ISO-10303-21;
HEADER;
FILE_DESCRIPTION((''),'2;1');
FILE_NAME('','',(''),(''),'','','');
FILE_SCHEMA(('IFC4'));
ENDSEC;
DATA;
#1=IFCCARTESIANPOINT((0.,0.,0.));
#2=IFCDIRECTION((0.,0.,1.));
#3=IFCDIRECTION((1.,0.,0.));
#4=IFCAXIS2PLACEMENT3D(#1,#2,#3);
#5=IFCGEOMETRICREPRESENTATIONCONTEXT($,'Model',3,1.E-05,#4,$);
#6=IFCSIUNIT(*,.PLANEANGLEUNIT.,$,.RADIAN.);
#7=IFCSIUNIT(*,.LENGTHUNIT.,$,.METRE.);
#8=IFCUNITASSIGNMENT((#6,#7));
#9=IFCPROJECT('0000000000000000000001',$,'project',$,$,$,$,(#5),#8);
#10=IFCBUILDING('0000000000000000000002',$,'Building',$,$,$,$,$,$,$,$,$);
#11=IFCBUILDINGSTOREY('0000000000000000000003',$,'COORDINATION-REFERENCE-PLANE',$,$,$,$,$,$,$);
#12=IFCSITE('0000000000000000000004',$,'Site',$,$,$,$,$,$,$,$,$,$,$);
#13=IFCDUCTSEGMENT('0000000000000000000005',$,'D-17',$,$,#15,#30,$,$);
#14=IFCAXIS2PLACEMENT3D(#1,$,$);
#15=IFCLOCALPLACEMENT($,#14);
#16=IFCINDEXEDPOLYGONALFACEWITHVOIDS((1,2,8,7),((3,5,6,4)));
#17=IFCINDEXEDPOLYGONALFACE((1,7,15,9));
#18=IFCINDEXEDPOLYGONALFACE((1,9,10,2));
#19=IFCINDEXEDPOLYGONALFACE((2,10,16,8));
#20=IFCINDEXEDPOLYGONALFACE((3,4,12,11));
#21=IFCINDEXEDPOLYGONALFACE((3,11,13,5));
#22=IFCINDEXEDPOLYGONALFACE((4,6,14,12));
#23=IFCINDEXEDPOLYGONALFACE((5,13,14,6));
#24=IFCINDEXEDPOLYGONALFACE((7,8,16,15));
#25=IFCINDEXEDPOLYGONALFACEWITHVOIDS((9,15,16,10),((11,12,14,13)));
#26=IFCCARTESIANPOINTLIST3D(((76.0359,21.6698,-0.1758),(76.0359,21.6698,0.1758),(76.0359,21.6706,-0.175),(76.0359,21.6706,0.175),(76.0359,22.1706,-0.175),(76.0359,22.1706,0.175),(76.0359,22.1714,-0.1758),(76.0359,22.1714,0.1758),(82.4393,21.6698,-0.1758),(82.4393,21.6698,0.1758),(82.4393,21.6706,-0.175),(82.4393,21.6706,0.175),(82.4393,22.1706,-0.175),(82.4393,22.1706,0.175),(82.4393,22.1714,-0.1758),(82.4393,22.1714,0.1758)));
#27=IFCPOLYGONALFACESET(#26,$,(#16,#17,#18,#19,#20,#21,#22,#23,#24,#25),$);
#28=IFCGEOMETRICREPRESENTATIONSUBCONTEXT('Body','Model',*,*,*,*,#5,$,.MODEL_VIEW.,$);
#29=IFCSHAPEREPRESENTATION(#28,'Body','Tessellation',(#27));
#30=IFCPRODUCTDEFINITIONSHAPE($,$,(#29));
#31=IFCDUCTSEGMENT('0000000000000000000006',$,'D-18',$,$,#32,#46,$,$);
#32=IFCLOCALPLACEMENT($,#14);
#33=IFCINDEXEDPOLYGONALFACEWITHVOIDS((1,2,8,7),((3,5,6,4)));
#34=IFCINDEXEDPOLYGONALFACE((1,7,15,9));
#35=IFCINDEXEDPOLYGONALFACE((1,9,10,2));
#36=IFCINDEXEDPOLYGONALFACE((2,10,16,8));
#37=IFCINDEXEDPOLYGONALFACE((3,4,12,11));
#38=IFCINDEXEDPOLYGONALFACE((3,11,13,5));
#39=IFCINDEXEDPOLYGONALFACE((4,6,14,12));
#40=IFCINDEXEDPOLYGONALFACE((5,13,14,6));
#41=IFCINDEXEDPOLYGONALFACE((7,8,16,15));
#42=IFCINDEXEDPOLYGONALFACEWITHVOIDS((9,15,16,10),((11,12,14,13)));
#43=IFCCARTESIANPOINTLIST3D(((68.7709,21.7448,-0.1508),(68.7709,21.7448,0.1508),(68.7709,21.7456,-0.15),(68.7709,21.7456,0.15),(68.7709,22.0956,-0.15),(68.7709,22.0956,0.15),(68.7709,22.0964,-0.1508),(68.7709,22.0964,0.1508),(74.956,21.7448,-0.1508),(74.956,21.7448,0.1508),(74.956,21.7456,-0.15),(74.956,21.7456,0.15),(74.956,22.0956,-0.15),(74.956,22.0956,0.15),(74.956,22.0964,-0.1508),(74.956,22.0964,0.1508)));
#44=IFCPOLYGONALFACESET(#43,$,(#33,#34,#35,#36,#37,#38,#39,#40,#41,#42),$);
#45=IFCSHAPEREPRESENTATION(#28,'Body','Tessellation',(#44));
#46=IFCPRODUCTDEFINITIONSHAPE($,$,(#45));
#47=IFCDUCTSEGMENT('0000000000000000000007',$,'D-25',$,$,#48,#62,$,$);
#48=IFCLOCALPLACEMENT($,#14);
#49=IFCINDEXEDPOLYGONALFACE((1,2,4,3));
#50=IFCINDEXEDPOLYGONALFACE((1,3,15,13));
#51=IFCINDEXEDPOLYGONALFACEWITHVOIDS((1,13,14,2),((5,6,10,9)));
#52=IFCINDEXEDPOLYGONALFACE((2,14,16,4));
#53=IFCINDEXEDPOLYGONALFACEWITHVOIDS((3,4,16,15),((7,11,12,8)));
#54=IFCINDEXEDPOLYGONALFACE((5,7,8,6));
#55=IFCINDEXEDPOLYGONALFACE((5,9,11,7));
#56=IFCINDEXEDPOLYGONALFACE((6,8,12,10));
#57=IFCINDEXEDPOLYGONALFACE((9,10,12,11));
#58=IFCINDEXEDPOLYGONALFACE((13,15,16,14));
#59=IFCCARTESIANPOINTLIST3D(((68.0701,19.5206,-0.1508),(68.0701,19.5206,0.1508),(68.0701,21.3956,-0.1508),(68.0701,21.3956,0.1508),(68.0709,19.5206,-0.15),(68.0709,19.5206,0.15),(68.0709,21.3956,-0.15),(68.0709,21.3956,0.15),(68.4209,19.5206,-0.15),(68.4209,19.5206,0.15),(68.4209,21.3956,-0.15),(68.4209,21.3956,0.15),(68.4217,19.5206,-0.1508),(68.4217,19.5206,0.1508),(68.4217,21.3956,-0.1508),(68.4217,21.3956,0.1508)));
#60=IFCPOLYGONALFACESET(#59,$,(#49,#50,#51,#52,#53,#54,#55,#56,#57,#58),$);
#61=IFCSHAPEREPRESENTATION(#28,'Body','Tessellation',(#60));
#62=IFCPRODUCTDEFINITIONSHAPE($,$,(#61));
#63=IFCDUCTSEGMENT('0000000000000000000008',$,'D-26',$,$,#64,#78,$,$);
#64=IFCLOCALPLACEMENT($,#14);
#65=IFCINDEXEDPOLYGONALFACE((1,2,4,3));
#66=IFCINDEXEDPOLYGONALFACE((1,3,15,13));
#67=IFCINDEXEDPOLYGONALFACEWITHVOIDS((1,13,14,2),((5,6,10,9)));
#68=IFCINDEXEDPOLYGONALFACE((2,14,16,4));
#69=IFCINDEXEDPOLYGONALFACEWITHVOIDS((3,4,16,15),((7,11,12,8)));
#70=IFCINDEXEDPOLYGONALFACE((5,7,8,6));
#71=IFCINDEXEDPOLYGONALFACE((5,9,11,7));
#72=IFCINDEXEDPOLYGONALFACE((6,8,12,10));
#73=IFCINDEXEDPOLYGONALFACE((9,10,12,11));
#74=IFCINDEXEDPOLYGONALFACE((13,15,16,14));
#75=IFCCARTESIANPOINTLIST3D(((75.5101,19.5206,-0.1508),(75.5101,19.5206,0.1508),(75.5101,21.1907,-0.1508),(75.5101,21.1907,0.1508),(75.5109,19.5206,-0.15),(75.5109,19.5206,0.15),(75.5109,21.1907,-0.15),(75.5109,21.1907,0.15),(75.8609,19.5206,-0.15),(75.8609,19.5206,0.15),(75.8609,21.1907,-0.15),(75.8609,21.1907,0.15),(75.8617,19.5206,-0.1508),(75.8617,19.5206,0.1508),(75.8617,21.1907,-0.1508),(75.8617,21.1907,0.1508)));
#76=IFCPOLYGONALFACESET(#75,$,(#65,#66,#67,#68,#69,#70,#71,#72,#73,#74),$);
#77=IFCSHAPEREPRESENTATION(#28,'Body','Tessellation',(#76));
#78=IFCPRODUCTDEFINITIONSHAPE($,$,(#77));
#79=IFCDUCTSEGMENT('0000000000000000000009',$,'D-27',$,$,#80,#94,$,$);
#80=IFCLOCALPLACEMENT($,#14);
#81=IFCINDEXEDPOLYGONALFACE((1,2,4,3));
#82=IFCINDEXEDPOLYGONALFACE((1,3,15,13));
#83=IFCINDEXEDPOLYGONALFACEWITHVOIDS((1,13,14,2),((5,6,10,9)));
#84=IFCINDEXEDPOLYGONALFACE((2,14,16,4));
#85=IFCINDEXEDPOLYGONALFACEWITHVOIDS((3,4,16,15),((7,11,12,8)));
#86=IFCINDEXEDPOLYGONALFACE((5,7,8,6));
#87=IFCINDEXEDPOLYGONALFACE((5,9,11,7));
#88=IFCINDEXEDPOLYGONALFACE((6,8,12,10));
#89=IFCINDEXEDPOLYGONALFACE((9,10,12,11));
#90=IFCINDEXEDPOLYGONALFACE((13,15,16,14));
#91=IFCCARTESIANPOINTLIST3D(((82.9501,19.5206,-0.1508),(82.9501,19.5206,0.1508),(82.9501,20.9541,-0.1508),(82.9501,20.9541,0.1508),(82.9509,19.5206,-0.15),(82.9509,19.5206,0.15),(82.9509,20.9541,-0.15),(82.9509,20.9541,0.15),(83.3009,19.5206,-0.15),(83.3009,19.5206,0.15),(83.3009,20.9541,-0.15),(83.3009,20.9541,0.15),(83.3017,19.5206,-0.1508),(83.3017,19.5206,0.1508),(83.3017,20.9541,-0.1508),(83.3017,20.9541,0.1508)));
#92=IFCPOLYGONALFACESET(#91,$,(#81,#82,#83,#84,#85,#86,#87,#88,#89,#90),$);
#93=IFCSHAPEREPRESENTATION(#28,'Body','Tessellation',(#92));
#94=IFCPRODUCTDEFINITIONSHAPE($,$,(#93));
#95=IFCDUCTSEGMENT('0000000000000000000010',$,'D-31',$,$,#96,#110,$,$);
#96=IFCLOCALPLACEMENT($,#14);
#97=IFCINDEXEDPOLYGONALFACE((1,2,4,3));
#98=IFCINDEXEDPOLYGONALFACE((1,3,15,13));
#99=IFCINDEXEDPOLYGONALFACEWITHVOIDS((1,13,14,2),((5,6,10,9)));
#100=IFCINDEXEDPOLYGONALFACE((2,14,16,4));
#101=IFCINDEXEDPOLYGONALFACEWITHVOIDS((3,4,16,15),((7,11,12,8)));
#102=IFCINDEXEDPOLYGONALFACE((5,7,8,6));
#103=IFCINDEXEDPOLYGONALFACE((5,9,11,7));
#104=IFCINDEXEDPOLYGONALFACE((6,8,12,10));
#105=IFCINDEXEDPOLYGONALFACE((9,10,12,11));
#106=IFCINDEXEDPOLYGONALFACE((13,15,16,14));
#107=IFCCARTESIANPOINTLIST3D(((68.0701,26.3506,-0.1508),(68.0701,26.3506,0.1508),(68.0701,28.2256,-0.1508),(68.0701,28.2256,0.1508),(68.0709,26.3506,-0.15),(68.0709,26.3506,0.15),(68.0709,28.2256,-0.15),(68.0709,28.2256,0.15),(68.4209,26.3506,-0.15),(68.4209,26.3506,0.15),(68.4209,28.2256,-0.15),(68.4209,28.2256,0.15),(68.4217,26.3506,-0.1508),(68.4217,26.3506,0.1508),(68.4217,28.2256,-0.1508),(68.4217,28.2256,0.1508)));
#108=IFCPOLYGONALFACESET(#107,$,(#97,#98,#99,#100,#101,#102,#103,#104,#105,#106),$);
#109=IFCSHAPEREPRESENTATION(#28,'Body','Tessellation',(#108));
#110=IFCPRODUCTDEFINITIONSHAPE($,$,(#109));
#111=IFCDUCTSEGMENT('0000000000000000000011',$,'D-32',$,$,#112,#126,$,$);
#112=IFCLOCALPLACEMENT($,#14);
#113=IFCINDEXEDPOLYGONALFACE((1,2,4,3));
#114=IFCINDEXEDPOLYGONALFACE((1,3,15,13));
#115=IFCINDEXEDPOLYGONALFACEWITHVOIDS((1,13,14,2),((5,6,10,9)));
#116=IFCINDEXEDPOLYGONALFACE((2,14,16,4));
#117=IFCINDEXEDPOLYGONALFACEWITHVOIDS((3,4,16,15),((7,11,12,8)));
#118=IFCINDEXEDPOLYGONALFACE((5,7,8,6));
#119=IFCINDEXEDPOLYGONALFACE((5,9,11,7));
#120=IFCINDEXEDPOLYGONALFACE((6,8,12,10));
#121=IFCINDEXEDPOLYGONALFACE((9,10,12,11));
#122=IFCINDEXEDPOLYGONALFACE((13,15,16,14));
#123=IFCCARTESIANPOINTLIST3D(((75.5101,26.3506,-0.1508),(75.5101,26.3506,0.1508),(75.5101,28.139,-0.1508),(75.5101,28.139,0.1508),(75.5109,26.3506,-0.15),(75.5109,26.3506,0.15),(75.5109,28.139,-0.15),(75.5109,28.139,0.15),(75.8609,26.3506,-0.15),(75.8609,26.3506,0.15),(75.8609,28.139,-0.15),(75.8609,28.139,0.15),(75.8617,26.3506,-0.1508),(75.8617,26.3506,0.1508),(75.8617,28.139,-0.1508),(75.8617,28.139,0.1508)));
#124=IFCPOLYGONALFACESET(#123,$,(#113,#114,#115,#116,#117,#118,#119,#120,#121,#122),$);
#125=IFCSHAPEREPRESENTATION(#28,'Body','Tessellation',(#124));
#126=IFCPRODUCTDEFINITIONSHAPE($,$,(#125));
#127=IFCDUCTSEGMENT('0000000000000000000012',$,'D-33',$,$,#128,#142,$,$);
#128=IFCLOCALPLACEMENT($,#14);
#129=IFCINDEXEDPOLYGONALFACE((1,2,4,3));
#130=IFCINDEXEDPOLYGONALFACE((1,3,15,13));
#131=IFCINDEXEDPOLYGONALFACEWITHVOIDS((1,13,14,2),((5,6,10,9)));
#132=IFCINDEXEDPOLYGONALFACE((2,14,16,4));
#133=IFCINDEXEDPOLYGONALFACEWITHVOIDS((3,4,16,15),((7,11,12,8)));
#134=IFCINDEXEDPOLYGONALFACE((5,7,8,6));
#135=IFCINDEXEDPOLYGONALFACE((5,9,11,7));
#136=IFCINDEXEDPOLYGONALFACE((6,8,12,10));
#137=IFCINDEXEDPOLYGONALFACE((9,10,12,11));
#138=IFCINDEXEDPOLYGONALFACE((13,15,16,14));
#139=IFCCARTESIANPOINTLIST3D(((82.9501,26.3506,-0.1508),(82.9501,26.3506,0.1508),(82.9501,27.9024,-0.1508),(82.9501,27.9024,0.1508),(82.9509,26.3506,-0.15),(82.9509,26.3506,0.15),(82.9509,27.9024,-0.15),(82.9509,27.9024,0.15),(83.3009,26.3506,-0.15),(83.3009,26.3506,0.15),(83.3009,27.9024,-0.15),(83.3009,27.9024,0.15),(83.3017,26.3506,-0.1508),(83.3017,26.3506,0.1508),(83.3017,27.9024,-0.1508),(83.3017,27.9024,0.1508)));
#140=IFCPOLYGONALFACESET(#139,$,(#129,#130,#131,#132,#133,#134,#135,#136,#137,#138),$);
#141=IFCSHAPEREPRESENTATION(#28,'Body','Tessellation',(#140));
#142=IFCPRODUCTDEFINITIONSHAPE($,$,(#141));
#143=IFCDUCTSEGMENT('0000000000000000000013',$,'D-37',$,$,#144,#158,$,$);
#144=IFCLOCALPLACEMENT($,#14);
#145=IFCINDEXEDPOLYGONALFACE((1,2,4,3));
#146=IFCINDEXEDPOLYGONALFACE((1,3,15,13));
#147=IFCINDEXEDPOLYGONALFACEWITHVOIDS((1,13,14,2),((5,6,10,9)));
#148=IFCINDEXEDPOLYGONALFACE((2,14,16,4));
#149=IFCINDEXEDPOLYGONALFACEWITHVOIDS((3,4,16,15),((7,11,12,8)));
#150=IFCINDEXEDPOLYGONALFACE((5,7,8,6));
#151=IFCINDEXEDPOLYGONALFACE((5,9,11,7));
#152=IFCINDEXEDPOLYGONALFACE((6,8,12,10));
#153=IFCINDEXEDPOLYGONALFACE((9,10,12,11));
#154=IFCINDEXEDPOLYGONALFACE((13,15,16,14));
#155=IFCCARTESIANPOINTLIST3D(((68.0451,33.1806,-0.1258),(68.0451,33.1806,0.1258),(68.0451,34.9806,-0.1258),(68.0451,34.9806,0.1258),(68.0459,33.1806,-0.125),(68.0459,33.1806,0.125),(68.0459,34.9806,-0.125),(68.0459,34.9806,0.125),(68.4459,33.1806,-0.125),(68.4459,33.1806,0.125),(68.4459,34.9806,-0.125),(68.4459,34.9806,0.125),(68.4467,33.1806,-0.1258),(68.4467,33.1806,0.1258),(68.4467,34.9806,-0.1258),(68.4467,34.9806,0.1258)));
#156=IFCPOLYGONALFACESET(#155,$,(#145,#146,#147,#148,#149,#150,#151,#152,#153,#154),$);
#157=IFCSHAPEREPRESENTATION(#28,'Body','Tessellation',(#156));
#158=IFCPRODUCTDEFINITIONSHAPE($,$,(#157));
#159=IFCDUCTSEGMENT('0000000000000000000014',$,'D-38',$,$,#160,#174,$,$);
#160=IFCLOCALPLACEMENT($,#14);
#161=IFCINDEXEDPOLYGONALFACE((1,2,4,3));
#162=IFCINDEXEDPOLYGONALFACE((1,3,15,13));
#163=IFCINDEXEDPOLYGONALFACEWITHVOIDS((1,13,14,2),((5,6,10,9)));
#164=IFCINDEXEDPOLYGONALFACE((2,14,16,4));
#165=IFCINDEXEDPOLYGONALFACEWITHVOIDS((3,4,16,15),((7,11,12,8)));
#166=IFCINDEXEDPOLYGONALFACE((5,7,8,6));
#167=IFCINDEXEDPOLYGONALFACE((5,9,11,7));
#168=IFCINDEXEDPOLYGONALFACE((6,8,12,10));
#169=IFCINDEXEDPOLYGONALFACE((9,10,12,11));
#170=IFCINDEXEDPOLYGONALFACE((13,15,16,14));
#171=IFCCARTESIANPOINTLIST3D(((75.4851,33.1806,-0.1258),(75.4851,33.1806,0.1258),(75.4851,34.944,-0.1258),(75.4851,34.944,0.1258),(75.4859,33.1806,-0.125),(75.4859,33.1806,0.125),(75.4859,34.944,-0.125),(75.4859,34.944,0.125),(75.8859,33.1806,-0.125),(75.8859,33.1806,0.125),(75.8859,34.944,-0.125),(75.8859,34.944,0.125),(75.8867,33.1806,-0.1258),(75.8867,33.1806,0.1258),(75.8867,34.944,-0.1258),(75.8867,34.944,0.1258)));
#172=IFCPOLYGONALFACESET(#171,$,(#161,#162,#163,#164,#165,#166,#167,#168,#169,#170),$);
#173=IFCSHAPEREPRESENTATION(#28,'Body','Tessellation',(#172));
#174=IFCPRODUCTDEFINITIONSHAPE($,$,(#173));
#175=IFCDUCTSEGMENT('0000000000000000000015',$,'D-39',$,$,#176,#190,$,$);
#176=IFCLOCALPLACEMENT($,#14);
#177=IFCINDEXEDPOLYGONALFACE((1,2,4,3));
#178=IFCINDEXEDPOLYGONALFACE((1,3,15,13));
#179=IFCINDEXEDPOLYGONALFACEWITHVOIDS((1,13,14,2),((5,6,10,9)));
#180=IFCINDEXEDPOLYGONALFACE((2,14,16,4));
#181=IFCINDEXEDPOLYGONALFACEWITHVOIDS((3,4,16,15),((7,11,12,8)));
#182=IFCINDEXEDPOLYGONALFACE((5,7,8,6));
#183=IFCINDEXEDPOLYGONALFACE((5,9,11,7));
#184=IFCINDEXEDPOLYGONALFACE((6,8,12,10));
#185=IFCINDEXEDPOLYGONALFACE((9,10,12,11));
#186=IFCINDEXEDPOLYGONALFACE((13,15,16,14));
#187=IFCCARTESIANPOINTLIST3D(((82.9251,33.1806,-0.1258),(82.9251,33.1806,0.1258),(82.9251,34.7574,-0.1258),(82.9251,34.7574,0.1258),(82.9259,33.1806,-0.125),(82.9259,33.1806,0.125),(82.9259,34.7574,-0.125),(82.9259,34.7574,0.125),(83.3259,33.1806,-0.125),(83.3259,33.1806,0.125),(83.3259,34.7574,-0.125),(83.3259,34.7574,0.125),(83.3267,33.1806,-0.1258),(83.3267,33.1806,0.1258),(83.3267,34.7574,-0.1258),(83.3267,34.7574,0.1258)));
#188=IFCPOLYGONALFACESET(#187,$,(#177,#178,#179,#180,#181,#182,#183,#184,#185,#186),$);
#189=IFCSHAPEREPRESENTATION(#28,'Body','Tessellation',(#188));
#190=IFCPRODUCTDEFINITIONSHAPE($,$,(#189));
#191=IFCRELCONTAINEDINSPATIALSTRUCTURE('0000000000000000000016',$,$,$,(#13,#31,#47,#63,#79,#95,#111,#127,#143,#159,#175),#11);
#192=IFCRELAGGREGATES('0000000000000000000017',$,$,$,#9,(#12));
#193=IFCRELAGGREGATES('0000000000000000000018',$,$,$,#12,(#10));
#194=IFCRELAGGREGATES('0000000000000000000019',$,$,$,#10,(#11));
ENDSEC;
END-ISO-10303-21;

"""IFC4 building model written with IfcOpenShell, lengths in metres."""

from ifc_helpers import new_model, si_unit, frame, origin, origin_with_axes, place, context, subcontext, project, spatial, hollow_rectangle, extrude, element, save


model = new_model("IFC4")

# Units and contexts
model_context = context("Model", 3, precision=1e-05, world=origin_with_axes())
body_context = subcontext(model_context, "Body", "Model", "MODEL_VIEW")
ifc_project = project(units=[si_unit("PLANEANGLEUNIT", "RADIAN"), si_unit("LENGTHUNIT", "METRE")], contexts=[model_context])

# Site, building, storey
site = spatial("IfcSite", under=ifc_project, Name="Site")
building = spatial("IfcBuilding", under=site, Name="Building")
storey = spatial("IfcBuildingStorey", under=building, Name="COORDINATION-REFERENCE-PLANE")

# Duct segments
duct_segment_1_placement = place(None, frame((76.0359, 21.9206, 0.0), z_axis=(1.0, 0.0, 0.0), x_axis=(0.0, 1.0, 0.0)))
element("IfcDuctSegment", 1, at=duct_segment_1_placement, inside=storey, Name="D-17", context=body_context, shape_type="SweptSolid", body=[
    extrude(hollow_rectangle(XDim=0.5016, YDim=0.3516, WallThickness=0.0008), origin(), (0.0, 0.0, 1.0), 6.4034),
])
duct_segment_2_placement = place(None, frame((68.7709, 21.9206, 0.0), z_axis=(1.0, 0.0, 0.0), x_axis=(0.0, 1.0, 0.0)))
element("IfcDuctSegment", 2, at=duct_segment_2_placement, inside=storey, Name="D-18", context=body_context, shape_type="SweptSolid", body=[
    extrude(hollow_rectangle(XDim=0.3516, YDim=0.3016, WallThickness=0.0008), origin(), (0.0, 0.0, 1.0), 6.1851),
])
duct_segment_3_placement = place(None, frame((68.2459, 19.5206, 0.0), z_axis=(0.0, 1.0, 0.0), x_axis=(1.0, 0.0, 0.0)))
element("IfcDuctSegment", 3, at=duct_segment_3_placement, inside=storey, Name="D-25", context=body_context, shape_type="SweptSolid", body=[
    extrude(hollow_rectangle(XDim=0.3516, YDim=0.3016, WallThickness=0.0008), origin(), (0.0, 0.0, 1.0), 1.875),
])
duct_segment_4_placement = place(None, frame((75.6859, 19.5206, 0.0), z_axis=(0.0, 1.0, 0.0), x_axis=(1.0, 0.0, 0.0)))
element("IfcDuctSegment", 4, at=duct_segment_4_placement, inside=storey, Name="D-26", context=body_context, shape_type="SweptSolid", body=[
    extrude(hollow_rectangle(XDim=0.3516, YDim=0.3016, WallThickness=0.0008), origin(), (0.0, 0.0, 1.0), 1.6701),
])
duct_segment_5_placement = place(None, frame((83.1259, 19.5206, 0.0), z_axis=(0.0, 1.0, 0.0), x_axis=(1.0, 0.0, 0.0)))
element("IfcDuctSegment", 5, at=duct_segment_5_placement, inside=storey, Name="D-27", context=body_context, shape_type="SweptSolid", body=[
    extrude(hollow_rectangle(XDim=0.3516, YDim=0.3016, WallThickness=0.0008), origin(), (0.0, 0.0, 1.0), 1.4335),
])
duct_segment_6_placement = place(None, frame((68.2459, 26.3506, 0.0), z_axis=(0.0, 1.0, 0.0), x_axis=(1.0, 0.0, 0.0)))
element("IfcDuctSegment", 6, at=duct_segment_6_placement, inside=storey, Name="D-31", context=body_context, shape_type="SweptSolid", body=[
    extrude(hollow_rectangle(XDim=0.3516, YDim=0.3016, WallThickness=0.0008), origin(), (0.0, 0.0, 1.0), 1.875),
])
duct_segment_7_placement = place(None, frame((75.6859, 26.3506, 0.0), z_axis=(0.0, 1.0, 0.0), x_axis=(1.0, 0.0, 0.0)))
element("IfcDuctSegment", 7, at=duct_segment_7_placement, inside=storey, Name="D-32", context=body_context, shape_type="SweptSolid", body=[
    extrude(hollow_rectangle(XDim=0.3516, YDim=0.3016, WallThickness=0.0008), origin(), (0.0, 0.0, 1.0), 1.7884),
])
duct_segment_8_placement = place(None, frame((83.1259, 26.3506, 0.0), z_axis=(0.0, 1.0, 0.0), x_axis=(1.0, 0.0, 0.0)))
element("IfcDuctSegment", 8, at=duct_segment_8_placement, inside=storey, Name="D-33", context=body_context, shape_type="SweptSolid", body=[
    extrude(hollow_rectangle(XDim=0.3516, YDim=0.3016, WallThickness=0.0008), origin(), (0.0, 0.0, 1.0), 1.5518),
])
duct_segment_9_placement = place(None, frame((68.2459, 33.1806, 0.0), z_axis=(0.0, 1.0, 0.0), x_axis=(1.0, 0.0, 0.0)))
element("IfcDuctSegment", 9, at=duct_segment_9_placement, inside=storey, Name="D-37", context=body_context, shape_type="SweptSolid", body=[
    extrude(hollow_rectangle(XDim=0.4016, YDim=0.2516, WallThickness=0.0008), origin(), (0.0, 0.0, 1.0), 1.8),
])
duct_segment_10_placement = place(None, frame((75.6859, 33.1806, 0.0), z_axis=(0.0, 1.0, 0.0), x_axis=(1.0, 0.0, 0.0)))
element("IfcDuctSegment", 10, at=duct_segment_10_placement, inside=storey, Name="D-38", context=body_context, shape_type="SweptSolid", body=[
    extrude(hollow_rectangle(XDim=0.4016, YDim=0.2516, WallThickness=0.0008), origin(), (0.0, 0.0, 1.0), 1.7634),
])
duct_segment_11_placement = place(None, frame((83.1259, 33.1806, 0.0), z_axis=(0.0, 1.0, 0.0), x_axis=(1.0, 0.0, 0.0)))
element("IfcDuctSegment", 11, at=duct_segment_11_placement, inside=storey, Name="D-39", context=body_context, shape_type="SweptSolid", body=[
    extrude(hollow_rectangle(XDim=0.4016, YDim=0.2516, WallThickness=0.0008), origin(), (0.0, 0.0, 1.0), 1.5768),
])

save(model, "model.ifc")
